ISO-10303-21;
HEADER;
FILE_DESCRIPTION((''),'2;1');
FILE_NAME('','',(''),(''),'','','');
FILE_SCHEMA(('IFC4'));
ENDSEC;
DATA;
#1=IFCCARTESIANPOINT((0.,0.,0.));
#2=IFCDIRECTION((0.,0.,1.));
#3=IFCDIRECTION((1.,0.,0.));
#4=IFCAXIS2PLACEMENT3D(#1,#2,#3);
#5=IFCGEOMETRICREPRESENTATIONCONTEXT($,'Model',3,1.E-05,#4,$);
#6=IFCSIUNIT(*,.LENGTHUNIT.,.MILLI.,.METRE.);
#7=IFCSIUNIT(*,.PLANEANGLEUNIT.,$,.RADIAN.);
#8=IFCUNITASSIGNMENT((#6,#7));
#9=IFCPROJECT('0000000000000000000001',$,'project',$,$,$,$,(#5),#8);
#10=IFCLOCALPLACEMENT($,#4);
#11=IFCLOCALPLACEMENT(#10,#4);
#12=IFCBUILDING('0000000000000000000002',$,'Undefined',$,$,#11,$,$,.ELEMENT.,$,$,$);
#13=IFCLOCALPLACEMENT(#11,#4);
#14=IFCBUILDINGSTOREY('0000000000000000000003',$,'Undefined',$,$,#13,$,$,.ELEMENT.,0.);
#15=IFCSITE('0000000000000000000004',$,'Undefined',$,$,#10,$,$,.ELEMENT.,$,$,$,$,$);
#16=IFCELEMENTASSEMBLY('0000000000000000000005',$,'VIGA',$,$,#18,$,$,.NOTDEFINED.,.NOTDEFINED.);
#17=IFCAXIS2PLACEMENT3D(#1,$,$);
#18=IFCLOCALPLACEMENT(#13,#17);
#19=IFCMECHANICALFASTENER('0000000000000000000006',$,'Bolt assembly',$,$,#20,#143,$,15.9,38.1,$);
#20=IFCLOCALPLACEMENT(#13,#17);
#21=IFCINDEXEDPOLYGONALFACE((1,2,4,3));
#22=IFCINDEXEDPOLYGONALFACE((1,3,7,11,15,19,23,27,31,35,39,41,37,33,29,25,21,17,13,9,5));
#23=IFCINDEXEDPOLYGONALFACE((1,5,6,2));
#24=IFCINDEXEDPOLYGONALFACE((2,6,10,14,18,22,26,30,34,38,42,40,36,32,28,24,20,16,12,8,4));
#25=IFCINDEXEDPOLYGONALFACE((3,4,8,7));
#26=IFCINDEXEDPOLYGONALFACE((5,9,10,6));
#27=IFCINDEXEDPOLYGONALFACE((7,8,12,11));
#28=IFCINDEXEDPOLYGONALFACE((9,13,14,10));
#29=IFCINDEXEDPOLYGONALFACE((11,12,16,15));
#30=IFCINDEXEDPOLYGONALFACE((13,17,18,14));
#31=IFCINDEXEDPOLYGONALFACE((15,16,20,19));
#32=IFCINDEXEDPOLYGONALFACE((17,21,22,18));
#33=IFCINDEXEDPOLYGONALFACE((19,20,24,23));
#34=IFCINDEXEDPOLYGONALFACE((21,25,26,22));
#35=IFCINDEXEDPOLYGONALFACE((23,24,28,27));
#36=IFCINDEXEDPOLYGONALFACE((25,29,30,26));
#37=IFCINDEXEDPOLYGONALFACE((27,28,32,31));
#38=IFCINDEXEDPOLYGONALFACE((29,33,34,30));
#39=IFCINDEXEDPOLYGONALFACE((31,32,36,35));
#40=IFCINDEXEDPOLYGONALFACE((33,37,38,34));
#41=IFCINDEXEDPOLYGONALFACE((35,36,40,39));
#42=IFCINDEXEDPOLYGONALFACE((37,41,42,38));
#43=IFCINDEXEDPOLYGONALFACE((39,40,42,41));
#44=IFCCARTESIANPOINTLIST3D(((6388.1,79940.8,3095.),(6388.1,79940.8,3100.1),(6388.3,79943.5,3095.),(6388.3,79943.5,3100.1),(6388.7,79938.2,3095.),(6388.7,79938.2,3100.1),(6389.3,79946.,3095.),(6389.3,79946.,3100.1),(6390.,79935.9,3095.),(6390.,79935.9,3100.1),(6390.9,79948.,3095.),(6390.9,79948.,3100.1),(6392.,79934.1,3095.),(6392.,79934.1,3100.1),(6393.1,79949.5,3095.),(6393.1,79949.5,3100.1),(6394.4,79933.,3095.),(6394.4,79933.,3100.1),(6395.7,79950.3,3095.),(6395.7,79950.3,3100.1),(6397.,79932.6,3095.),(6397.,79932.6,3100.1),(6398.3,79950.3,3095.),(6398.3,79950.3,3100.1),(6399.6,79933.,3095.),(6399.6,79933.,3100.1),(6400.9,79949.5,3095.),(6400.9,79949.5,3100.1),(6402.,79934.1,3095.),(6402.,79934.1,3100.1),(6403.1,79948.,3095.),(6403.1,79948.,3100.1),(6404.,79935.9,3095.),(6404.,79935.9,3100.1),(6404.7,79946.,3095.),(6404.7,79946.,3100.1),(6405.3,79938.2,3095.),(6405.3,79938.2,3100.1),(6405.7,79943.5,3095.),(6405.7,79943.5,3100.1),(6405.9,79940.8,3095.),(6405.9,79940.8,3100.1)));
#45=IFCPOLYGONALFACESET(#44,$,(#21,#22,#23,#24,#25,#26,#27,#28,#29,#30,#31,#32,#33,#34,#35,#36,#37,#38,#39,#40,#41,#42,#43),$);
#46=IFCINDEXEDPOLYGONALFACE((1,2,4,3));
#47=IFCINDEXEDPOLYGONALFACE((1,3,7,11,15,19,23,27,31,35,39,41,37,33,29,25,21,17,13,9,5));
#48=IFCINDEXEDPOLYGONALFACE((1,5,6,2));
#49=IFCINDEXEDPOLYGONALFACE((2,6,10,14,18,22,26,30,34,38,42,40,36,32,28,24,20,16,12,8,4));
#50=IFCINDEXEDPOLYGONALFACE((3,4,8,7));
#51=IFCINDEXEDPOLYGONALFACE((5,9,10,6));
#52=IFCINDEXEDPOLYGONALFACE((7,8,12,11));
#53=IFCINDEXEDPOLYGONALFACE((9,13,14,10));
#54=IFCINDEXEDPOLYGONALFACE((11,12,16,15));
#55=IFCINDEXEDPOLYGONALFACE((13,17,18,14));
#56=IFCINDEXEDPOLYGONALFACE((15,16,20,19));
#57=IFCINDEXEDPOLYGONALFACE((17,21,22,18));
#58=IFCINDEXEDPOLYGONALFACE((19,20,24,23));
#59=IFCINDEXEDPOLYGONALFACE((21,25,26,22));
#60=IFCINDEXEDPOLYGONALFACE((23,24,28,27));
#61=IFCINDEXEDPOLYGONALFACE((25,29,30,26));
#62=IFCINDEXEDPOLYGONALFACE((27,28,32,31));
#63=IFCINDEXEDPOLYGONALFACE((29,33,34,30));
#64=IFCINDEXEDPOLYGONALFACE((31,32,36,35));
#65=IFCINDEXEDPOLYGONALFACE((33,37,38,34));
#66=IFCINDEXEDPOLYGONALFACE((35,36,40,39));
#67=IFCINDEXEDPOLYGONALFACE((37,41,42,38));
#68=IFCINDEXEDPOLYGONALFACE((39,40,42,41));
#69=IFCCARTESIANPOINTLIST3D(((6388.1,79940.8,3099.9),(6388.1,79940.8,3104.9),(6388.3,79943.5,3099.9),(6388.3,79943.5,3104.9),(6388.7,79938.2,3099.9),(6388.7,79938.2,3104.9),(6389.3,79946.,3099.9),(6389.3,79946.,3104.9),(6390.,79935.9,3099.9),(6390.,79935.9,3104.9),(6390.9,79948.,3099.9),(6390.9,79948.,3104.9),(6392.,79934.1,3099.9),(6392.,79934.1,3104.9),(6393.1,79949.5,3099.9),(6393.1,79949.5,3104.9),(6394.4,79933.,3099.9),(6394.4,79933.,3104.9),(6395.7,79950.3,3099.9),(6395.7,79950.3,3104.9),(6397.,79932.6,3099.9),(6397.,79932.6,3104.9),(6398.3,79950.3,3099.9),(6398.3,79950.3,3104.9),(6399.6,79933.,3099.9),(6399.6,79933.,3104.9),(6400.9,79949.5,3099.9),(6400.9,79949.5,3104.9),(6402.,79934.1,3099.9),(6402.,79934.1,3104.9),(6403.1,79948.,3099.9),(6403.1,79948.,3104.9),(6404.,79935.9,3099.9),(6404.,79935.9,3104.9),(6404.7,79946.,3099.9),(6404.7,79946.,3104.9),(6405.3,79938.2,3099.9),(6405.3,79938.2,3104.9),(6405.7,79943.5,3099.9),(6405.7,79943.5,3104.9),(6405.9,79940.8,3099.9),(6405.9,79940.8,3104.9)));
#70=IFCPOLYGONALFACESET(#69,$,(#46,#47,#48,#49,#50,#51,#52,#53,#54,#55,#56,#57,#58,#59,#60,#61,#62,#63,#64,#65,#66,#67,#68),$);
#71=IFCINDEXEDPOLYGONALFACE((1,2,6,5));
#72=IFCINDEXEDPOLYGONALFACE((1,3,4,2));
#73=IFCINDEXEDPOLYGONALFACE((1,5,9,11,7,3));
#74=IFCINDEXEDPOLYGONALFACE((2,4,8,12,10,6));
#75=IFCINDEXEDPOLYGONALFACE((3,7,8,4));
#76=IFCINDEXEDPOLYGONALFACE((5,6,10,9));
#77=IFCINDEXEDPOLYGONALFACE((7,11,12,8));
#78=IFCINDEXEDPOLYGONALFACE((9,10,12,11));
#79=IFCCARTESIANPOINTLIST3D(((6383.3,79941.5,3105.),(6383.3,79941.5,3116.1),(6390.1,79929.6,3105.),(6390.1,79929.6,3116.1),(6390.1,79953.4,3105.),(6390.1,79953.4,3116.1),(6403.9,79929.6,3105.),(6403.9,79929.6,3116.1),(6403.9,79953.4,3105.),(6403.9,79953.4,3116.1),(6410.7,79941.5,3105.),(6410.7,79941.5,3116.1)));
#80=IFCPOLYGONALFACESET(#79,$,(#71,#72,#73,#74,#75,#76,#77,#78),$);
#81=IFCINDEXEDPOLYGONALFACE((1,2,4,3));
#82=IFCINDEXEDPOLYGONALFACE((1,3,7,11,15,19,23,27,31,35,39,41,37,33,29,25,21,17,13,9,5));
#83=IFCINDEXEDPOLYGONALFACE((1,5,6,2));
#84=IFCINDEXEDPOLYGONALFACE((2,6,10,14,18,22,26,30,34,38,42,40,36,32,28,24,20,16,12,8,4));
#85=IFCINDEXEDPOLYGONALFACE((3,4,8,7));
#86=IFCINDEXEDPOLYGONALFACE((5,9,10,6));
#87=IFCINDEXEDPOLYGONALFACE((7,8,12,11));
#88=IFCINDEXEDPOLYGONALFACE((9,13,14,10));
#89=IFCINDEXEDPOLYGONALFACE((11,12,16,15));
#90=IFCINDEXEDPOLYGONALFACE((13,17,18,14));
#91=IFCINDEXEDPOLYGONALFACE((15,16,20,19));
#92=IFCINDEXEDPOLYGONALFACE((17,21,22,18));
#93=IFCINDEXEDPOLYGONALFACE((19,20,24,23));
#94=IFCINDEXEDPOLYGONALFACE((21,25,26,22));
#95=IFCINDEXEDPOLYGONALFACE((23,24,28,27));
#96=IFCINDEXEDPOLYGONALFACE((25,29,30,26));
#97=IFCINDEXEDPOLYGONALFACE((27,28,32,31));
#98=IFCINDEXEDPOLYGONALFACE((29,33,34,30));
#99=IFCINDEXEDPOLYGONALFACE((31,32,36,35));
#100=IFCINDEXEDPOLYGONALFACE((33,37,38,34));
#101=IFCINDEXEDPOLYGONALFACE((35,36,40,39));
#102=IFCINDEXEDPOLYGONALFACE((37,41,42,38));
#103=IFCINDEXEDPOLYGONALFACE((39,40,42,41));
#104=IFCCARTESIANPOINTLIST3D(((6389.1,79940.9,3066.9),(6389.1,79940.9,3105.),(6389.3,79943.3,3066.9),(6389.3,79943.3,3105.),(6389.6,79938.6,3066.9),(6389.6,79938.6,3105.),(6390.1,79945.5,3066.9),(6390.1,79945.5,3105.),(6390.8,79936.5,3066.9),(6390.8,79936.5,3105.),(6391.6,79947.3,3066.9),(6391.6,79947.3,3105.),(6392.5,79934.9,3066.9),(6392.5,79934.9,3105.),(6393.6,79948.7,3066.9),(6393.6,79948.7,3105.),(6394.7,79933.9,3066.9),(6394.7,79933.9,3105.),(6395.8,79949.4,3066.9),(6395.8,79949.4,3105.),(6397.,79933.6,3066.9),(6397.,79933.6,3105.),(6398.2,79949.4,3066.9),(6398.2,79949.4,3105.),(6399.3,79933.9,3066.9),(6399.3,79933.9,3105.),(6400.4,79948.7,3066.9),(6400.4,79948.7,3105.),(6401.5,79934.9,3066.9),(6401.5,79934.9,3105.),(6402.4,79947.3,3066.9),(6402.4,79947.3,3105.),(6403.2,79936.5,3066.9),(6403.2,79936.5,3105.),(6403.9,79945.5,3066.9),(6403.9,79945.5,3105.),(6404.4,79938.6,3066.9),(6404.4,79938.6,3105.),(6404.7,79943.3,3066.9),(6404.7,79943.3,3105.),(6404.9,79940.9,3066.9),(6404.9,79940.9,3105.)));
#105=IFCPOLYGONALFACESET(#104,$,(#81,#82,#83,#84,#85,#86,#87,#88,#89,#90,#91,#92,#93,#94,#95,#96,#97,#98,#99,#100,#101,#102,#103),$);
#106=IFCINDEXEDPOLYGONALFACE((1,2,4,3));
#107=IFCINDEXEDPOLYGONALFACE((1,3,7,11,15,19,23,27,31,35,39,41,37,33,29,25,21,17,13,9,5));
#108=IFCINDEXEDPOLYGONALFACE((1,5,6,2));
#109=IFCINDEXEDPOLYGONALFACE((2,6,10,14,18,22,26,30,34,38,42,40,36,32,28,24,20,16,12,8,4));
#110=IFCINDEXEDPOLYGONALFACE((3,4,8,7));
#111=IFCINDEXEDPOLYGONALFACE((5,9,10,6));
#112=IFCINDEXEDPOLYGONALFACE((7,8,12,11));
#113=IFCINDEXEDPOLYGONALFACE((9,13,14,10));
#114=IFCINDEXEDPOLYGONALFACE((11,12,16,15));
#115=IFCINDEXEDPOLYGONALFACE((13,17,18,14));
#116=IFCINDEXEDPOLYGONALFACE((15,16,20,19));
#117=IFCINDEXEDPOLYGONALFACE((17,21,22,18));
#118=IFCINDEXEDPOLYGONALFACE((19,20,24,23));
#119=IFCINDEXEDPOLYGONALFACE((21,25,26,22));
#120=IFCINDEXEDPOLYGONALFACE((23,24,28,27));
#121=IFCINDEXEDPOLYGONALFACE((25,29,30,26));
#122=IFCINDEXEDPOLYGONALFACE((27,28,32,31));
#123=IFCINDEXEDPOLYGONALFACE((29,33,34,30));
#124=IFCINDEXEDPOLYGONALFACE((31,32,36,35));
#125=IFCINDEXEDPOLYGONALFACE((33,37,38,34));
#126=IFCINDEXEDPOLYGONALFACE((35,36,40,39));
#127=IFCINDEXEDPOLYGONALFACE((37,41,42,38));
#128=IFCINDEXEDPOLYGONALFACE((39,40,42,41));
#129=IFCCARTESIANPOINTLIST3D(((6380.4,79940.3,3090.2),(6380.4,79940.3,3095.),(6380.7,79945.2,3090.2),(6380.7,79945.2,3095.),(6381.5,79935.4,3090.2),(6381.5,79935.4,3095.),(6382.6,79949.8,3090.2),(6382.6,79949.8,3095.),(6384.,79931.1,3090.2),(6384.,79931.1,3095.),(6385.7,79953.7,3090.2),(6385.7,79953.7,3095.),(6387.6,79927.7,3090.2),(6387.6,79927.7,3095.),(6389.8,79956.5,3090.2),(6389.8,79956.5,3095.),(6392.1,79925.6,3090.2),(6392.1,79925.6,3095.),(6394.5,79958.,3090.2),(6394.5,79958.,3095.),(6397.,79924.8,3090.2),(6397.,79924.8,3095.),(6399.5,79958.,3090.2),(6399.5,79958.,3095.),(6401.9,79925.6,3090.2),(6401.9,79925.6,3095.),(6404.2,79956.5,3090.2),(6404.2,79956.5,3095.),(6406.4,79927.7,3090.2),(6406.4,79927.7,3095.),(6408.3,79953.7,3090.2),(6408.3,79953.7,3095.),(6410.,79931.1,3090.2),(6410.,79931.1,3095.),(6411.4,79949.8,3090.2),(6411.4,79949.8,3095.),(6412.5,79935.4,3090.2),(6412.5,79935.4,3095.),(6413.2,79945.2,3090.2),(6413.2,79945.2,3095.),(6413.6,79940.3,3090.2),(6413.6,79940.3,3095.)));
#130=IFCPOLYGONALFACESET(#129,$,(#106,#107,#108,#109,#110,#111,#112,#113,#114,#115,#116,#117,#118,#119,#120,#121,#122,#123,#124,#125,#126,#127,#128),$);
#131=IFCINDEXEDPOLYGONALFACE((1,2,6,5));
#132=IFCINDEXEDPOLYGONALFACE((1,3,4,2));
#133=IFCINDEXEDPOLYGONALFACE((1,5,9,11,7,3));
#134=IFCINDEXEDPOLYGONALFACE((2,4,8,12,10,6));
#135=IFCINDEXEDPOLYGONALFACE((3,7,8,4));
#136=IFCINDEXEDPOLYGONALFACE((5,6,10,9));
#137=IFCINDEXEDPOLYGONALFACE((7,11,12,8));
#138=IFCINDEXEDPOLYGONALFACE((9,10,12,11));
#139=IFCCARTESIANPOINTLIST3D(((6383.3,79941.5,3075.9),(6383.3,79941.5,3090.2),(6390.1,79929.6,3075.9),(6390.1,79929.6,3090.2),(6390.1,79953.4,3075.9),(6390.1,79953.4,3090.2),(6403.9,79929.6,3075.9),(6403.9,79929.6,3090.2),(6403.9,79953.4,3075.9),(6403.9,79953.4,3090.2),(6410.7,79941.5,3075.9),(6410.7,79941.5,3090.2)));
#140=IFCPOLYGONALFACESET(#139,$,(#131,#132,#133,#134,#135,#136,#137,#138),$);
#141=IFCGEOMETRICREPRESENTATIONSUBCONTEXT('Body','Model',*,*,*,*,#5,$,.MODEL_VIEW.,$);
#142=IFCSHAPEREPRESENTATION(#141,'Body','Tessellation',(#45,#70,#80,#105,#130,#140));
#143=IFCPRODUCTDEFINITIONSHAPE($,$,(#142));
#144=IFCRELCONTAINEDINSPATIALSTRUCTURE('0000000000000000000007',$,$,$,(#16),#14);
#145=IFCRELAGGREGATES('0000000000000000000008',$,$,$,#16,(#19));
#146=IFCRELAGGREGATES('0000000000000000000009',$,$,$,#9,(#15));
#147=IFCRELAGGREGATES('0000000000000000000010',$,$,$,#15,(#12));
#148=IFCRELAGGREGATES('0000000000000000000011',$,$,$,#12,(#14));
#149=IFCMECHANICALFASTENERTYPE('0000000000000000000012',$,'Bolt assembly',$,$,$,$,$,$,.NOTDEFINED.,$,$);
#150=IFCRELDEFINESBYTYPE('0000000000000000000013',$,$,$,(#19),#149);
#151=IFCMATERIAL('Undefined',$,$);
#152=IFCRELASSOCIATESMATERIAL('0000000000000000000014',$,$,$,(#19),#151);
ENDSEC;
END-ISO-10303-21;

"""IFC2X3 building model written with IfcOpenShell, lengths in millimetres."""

from ifc_helpers import new_model, si_unit, frame, origin_with_axes, origin_2d_with_axis, place, context, subcontext, project, spatial, polyline, circle, outline, extrude, source, transform, mapped, material, type_object, element, aggregate, save


model = new_model("IFC2X3")

# Units and contexts
model_context = context("Model", 3, precision=1e-05, world=origin_with_axes())
body_context = subcontext(model_context, "Body", "Model", "MODEL_VIEW")
ifc_project = project(units=[si_unit("LENGTHUNIT", "METRE", prefix="MILLI"), si_unit("PLANEANGLEUNIT", "RADIAN")], contexts=[model_context])

# Site, building, storey
site_placement = place(None, origin_with_axes())
site = spatial("IfcSite", under=ifc_project, at=site_placement, Name="Undefined", CompositionType="ELEMENT")
building_placement = place(site_placement, origin_with_axes())
building = spatial("IfcBuilding", under=site, at=building_placement, Name="Undefined", CompositionType="ELEMENT")
storey_placement = place(building_placement, origin_with_axes())
storey = spatial("IfcBuildingStorey", under=building, at=storey_placement, Name="Undefined", CompositionType="ELEMENT", Elevation=0.0)

# Element assembly
assembly_1_placement = place(storey_placement, origin_with_axes())
assembly_1 = element("IfcElementAssembly", 1, at=assembly_1_placement, inside=storey, Name="VIGA", AssemblyPlace="NOTDEFINED", PredefinedType="NOTDEFINED")

# Mechanical fastener
ifc_material_1 = material(Name="Undefined")
mechanical_fastener_type = type_object("IfcMechanicalFastenerType", Name="Bolt assembly")
shared_shape_1 = source(origin_with_axes(), body_context, "Body", "SweptSolid", [
    extrude(circle(Radius=8.9, at=origin_2d_with_axis()), frame((0.0, -0.1, 0.0), z_axis=(0.0, 1.0, 0.0), x_axis=(1.0, 0.0, 0.0)), (0.0, 0.0, 1.0), 5.1),
    extrude(circle(Radius=8.9, at=origin_2d_with_axis()), frame((0.0, -4.9, 0.0), z_axis=(0.0, 1.0, 0.0), x_axis=(1.0, 0.0, 0.0)), (0.0, 0.0, 1.0), 5.0),
    extrude(outline(polyline([(11.9, -6.9), (11.9, 6.9), (0.0, 13.7), (-11.9, 6.9), (-11.9, -6.9), (0.0, -13.7), (11.9, -6.9)])), frame((0.0, -16.1, 0.0), z_axis=(0.0, 1.0, 0.0), x_axis=(1.0, 0.0, 0.0)), (0.0, 0.0, 1.0), 11.1),
    extrude(circle(Radius=7.9, at=origin_2d_with_axis()), frame((0.0, -5.0, 0.0), z_axis=(0.0, 1.0, 0.0), x_axis=(1.0, 0.0, 0.0)), (0.0, 0.0, 1.0), 38.1),
    extrude(circle(Radius=16.7, at=origin_2d_with_axis()), frame((0.0, 5.0, 0.0), z_axis=(0.0, 1.0, 0.0), x_axis=(1.0, 0.0, 0.0)), (0.0, 0.0, 1.0), 4.8),
    extrude(outline(polyline([(11.9, -6.9), (11.9, 6.9), (0.0, 13.7), (-11.9, 6.9), (-11.9, -6.9), (0.0, -13.7), (11.9, -6.9)])), frame((0.0, 9.8, 0.0), z_axis=(0.0, 1.0, 0.0), x_axis=(1.0, 0.0, 0.0)), (0.0, 0.0, 1.0), 14.3),
])
mechanical_fastener_1_placement = place(assembly_1_placement, frame((6397.0, 79941.5, 3100.0), z_axis=(1.0, 0.000006, 0.0), x_axis=(0.000006, -1.0, 0.0)))
mechanical_fastener_1 = element("IfcMechanicalFastener", 2, at=mechanical_fastener_1_placement, type_object=mechanical_fastener_type, material=ifc_material_1, Name="Bolt assembly", NominalDiameter=15.9, NominalLength=38.1, context=body_context, shape_type="MappedRepresentation", body=[
    mapped(shared_shape_1, transform((0.0, 0.0, 0.0))),
])
aggregate(assembly_1, [mechanical_fastener_1])

save(model, "model.ifc")
